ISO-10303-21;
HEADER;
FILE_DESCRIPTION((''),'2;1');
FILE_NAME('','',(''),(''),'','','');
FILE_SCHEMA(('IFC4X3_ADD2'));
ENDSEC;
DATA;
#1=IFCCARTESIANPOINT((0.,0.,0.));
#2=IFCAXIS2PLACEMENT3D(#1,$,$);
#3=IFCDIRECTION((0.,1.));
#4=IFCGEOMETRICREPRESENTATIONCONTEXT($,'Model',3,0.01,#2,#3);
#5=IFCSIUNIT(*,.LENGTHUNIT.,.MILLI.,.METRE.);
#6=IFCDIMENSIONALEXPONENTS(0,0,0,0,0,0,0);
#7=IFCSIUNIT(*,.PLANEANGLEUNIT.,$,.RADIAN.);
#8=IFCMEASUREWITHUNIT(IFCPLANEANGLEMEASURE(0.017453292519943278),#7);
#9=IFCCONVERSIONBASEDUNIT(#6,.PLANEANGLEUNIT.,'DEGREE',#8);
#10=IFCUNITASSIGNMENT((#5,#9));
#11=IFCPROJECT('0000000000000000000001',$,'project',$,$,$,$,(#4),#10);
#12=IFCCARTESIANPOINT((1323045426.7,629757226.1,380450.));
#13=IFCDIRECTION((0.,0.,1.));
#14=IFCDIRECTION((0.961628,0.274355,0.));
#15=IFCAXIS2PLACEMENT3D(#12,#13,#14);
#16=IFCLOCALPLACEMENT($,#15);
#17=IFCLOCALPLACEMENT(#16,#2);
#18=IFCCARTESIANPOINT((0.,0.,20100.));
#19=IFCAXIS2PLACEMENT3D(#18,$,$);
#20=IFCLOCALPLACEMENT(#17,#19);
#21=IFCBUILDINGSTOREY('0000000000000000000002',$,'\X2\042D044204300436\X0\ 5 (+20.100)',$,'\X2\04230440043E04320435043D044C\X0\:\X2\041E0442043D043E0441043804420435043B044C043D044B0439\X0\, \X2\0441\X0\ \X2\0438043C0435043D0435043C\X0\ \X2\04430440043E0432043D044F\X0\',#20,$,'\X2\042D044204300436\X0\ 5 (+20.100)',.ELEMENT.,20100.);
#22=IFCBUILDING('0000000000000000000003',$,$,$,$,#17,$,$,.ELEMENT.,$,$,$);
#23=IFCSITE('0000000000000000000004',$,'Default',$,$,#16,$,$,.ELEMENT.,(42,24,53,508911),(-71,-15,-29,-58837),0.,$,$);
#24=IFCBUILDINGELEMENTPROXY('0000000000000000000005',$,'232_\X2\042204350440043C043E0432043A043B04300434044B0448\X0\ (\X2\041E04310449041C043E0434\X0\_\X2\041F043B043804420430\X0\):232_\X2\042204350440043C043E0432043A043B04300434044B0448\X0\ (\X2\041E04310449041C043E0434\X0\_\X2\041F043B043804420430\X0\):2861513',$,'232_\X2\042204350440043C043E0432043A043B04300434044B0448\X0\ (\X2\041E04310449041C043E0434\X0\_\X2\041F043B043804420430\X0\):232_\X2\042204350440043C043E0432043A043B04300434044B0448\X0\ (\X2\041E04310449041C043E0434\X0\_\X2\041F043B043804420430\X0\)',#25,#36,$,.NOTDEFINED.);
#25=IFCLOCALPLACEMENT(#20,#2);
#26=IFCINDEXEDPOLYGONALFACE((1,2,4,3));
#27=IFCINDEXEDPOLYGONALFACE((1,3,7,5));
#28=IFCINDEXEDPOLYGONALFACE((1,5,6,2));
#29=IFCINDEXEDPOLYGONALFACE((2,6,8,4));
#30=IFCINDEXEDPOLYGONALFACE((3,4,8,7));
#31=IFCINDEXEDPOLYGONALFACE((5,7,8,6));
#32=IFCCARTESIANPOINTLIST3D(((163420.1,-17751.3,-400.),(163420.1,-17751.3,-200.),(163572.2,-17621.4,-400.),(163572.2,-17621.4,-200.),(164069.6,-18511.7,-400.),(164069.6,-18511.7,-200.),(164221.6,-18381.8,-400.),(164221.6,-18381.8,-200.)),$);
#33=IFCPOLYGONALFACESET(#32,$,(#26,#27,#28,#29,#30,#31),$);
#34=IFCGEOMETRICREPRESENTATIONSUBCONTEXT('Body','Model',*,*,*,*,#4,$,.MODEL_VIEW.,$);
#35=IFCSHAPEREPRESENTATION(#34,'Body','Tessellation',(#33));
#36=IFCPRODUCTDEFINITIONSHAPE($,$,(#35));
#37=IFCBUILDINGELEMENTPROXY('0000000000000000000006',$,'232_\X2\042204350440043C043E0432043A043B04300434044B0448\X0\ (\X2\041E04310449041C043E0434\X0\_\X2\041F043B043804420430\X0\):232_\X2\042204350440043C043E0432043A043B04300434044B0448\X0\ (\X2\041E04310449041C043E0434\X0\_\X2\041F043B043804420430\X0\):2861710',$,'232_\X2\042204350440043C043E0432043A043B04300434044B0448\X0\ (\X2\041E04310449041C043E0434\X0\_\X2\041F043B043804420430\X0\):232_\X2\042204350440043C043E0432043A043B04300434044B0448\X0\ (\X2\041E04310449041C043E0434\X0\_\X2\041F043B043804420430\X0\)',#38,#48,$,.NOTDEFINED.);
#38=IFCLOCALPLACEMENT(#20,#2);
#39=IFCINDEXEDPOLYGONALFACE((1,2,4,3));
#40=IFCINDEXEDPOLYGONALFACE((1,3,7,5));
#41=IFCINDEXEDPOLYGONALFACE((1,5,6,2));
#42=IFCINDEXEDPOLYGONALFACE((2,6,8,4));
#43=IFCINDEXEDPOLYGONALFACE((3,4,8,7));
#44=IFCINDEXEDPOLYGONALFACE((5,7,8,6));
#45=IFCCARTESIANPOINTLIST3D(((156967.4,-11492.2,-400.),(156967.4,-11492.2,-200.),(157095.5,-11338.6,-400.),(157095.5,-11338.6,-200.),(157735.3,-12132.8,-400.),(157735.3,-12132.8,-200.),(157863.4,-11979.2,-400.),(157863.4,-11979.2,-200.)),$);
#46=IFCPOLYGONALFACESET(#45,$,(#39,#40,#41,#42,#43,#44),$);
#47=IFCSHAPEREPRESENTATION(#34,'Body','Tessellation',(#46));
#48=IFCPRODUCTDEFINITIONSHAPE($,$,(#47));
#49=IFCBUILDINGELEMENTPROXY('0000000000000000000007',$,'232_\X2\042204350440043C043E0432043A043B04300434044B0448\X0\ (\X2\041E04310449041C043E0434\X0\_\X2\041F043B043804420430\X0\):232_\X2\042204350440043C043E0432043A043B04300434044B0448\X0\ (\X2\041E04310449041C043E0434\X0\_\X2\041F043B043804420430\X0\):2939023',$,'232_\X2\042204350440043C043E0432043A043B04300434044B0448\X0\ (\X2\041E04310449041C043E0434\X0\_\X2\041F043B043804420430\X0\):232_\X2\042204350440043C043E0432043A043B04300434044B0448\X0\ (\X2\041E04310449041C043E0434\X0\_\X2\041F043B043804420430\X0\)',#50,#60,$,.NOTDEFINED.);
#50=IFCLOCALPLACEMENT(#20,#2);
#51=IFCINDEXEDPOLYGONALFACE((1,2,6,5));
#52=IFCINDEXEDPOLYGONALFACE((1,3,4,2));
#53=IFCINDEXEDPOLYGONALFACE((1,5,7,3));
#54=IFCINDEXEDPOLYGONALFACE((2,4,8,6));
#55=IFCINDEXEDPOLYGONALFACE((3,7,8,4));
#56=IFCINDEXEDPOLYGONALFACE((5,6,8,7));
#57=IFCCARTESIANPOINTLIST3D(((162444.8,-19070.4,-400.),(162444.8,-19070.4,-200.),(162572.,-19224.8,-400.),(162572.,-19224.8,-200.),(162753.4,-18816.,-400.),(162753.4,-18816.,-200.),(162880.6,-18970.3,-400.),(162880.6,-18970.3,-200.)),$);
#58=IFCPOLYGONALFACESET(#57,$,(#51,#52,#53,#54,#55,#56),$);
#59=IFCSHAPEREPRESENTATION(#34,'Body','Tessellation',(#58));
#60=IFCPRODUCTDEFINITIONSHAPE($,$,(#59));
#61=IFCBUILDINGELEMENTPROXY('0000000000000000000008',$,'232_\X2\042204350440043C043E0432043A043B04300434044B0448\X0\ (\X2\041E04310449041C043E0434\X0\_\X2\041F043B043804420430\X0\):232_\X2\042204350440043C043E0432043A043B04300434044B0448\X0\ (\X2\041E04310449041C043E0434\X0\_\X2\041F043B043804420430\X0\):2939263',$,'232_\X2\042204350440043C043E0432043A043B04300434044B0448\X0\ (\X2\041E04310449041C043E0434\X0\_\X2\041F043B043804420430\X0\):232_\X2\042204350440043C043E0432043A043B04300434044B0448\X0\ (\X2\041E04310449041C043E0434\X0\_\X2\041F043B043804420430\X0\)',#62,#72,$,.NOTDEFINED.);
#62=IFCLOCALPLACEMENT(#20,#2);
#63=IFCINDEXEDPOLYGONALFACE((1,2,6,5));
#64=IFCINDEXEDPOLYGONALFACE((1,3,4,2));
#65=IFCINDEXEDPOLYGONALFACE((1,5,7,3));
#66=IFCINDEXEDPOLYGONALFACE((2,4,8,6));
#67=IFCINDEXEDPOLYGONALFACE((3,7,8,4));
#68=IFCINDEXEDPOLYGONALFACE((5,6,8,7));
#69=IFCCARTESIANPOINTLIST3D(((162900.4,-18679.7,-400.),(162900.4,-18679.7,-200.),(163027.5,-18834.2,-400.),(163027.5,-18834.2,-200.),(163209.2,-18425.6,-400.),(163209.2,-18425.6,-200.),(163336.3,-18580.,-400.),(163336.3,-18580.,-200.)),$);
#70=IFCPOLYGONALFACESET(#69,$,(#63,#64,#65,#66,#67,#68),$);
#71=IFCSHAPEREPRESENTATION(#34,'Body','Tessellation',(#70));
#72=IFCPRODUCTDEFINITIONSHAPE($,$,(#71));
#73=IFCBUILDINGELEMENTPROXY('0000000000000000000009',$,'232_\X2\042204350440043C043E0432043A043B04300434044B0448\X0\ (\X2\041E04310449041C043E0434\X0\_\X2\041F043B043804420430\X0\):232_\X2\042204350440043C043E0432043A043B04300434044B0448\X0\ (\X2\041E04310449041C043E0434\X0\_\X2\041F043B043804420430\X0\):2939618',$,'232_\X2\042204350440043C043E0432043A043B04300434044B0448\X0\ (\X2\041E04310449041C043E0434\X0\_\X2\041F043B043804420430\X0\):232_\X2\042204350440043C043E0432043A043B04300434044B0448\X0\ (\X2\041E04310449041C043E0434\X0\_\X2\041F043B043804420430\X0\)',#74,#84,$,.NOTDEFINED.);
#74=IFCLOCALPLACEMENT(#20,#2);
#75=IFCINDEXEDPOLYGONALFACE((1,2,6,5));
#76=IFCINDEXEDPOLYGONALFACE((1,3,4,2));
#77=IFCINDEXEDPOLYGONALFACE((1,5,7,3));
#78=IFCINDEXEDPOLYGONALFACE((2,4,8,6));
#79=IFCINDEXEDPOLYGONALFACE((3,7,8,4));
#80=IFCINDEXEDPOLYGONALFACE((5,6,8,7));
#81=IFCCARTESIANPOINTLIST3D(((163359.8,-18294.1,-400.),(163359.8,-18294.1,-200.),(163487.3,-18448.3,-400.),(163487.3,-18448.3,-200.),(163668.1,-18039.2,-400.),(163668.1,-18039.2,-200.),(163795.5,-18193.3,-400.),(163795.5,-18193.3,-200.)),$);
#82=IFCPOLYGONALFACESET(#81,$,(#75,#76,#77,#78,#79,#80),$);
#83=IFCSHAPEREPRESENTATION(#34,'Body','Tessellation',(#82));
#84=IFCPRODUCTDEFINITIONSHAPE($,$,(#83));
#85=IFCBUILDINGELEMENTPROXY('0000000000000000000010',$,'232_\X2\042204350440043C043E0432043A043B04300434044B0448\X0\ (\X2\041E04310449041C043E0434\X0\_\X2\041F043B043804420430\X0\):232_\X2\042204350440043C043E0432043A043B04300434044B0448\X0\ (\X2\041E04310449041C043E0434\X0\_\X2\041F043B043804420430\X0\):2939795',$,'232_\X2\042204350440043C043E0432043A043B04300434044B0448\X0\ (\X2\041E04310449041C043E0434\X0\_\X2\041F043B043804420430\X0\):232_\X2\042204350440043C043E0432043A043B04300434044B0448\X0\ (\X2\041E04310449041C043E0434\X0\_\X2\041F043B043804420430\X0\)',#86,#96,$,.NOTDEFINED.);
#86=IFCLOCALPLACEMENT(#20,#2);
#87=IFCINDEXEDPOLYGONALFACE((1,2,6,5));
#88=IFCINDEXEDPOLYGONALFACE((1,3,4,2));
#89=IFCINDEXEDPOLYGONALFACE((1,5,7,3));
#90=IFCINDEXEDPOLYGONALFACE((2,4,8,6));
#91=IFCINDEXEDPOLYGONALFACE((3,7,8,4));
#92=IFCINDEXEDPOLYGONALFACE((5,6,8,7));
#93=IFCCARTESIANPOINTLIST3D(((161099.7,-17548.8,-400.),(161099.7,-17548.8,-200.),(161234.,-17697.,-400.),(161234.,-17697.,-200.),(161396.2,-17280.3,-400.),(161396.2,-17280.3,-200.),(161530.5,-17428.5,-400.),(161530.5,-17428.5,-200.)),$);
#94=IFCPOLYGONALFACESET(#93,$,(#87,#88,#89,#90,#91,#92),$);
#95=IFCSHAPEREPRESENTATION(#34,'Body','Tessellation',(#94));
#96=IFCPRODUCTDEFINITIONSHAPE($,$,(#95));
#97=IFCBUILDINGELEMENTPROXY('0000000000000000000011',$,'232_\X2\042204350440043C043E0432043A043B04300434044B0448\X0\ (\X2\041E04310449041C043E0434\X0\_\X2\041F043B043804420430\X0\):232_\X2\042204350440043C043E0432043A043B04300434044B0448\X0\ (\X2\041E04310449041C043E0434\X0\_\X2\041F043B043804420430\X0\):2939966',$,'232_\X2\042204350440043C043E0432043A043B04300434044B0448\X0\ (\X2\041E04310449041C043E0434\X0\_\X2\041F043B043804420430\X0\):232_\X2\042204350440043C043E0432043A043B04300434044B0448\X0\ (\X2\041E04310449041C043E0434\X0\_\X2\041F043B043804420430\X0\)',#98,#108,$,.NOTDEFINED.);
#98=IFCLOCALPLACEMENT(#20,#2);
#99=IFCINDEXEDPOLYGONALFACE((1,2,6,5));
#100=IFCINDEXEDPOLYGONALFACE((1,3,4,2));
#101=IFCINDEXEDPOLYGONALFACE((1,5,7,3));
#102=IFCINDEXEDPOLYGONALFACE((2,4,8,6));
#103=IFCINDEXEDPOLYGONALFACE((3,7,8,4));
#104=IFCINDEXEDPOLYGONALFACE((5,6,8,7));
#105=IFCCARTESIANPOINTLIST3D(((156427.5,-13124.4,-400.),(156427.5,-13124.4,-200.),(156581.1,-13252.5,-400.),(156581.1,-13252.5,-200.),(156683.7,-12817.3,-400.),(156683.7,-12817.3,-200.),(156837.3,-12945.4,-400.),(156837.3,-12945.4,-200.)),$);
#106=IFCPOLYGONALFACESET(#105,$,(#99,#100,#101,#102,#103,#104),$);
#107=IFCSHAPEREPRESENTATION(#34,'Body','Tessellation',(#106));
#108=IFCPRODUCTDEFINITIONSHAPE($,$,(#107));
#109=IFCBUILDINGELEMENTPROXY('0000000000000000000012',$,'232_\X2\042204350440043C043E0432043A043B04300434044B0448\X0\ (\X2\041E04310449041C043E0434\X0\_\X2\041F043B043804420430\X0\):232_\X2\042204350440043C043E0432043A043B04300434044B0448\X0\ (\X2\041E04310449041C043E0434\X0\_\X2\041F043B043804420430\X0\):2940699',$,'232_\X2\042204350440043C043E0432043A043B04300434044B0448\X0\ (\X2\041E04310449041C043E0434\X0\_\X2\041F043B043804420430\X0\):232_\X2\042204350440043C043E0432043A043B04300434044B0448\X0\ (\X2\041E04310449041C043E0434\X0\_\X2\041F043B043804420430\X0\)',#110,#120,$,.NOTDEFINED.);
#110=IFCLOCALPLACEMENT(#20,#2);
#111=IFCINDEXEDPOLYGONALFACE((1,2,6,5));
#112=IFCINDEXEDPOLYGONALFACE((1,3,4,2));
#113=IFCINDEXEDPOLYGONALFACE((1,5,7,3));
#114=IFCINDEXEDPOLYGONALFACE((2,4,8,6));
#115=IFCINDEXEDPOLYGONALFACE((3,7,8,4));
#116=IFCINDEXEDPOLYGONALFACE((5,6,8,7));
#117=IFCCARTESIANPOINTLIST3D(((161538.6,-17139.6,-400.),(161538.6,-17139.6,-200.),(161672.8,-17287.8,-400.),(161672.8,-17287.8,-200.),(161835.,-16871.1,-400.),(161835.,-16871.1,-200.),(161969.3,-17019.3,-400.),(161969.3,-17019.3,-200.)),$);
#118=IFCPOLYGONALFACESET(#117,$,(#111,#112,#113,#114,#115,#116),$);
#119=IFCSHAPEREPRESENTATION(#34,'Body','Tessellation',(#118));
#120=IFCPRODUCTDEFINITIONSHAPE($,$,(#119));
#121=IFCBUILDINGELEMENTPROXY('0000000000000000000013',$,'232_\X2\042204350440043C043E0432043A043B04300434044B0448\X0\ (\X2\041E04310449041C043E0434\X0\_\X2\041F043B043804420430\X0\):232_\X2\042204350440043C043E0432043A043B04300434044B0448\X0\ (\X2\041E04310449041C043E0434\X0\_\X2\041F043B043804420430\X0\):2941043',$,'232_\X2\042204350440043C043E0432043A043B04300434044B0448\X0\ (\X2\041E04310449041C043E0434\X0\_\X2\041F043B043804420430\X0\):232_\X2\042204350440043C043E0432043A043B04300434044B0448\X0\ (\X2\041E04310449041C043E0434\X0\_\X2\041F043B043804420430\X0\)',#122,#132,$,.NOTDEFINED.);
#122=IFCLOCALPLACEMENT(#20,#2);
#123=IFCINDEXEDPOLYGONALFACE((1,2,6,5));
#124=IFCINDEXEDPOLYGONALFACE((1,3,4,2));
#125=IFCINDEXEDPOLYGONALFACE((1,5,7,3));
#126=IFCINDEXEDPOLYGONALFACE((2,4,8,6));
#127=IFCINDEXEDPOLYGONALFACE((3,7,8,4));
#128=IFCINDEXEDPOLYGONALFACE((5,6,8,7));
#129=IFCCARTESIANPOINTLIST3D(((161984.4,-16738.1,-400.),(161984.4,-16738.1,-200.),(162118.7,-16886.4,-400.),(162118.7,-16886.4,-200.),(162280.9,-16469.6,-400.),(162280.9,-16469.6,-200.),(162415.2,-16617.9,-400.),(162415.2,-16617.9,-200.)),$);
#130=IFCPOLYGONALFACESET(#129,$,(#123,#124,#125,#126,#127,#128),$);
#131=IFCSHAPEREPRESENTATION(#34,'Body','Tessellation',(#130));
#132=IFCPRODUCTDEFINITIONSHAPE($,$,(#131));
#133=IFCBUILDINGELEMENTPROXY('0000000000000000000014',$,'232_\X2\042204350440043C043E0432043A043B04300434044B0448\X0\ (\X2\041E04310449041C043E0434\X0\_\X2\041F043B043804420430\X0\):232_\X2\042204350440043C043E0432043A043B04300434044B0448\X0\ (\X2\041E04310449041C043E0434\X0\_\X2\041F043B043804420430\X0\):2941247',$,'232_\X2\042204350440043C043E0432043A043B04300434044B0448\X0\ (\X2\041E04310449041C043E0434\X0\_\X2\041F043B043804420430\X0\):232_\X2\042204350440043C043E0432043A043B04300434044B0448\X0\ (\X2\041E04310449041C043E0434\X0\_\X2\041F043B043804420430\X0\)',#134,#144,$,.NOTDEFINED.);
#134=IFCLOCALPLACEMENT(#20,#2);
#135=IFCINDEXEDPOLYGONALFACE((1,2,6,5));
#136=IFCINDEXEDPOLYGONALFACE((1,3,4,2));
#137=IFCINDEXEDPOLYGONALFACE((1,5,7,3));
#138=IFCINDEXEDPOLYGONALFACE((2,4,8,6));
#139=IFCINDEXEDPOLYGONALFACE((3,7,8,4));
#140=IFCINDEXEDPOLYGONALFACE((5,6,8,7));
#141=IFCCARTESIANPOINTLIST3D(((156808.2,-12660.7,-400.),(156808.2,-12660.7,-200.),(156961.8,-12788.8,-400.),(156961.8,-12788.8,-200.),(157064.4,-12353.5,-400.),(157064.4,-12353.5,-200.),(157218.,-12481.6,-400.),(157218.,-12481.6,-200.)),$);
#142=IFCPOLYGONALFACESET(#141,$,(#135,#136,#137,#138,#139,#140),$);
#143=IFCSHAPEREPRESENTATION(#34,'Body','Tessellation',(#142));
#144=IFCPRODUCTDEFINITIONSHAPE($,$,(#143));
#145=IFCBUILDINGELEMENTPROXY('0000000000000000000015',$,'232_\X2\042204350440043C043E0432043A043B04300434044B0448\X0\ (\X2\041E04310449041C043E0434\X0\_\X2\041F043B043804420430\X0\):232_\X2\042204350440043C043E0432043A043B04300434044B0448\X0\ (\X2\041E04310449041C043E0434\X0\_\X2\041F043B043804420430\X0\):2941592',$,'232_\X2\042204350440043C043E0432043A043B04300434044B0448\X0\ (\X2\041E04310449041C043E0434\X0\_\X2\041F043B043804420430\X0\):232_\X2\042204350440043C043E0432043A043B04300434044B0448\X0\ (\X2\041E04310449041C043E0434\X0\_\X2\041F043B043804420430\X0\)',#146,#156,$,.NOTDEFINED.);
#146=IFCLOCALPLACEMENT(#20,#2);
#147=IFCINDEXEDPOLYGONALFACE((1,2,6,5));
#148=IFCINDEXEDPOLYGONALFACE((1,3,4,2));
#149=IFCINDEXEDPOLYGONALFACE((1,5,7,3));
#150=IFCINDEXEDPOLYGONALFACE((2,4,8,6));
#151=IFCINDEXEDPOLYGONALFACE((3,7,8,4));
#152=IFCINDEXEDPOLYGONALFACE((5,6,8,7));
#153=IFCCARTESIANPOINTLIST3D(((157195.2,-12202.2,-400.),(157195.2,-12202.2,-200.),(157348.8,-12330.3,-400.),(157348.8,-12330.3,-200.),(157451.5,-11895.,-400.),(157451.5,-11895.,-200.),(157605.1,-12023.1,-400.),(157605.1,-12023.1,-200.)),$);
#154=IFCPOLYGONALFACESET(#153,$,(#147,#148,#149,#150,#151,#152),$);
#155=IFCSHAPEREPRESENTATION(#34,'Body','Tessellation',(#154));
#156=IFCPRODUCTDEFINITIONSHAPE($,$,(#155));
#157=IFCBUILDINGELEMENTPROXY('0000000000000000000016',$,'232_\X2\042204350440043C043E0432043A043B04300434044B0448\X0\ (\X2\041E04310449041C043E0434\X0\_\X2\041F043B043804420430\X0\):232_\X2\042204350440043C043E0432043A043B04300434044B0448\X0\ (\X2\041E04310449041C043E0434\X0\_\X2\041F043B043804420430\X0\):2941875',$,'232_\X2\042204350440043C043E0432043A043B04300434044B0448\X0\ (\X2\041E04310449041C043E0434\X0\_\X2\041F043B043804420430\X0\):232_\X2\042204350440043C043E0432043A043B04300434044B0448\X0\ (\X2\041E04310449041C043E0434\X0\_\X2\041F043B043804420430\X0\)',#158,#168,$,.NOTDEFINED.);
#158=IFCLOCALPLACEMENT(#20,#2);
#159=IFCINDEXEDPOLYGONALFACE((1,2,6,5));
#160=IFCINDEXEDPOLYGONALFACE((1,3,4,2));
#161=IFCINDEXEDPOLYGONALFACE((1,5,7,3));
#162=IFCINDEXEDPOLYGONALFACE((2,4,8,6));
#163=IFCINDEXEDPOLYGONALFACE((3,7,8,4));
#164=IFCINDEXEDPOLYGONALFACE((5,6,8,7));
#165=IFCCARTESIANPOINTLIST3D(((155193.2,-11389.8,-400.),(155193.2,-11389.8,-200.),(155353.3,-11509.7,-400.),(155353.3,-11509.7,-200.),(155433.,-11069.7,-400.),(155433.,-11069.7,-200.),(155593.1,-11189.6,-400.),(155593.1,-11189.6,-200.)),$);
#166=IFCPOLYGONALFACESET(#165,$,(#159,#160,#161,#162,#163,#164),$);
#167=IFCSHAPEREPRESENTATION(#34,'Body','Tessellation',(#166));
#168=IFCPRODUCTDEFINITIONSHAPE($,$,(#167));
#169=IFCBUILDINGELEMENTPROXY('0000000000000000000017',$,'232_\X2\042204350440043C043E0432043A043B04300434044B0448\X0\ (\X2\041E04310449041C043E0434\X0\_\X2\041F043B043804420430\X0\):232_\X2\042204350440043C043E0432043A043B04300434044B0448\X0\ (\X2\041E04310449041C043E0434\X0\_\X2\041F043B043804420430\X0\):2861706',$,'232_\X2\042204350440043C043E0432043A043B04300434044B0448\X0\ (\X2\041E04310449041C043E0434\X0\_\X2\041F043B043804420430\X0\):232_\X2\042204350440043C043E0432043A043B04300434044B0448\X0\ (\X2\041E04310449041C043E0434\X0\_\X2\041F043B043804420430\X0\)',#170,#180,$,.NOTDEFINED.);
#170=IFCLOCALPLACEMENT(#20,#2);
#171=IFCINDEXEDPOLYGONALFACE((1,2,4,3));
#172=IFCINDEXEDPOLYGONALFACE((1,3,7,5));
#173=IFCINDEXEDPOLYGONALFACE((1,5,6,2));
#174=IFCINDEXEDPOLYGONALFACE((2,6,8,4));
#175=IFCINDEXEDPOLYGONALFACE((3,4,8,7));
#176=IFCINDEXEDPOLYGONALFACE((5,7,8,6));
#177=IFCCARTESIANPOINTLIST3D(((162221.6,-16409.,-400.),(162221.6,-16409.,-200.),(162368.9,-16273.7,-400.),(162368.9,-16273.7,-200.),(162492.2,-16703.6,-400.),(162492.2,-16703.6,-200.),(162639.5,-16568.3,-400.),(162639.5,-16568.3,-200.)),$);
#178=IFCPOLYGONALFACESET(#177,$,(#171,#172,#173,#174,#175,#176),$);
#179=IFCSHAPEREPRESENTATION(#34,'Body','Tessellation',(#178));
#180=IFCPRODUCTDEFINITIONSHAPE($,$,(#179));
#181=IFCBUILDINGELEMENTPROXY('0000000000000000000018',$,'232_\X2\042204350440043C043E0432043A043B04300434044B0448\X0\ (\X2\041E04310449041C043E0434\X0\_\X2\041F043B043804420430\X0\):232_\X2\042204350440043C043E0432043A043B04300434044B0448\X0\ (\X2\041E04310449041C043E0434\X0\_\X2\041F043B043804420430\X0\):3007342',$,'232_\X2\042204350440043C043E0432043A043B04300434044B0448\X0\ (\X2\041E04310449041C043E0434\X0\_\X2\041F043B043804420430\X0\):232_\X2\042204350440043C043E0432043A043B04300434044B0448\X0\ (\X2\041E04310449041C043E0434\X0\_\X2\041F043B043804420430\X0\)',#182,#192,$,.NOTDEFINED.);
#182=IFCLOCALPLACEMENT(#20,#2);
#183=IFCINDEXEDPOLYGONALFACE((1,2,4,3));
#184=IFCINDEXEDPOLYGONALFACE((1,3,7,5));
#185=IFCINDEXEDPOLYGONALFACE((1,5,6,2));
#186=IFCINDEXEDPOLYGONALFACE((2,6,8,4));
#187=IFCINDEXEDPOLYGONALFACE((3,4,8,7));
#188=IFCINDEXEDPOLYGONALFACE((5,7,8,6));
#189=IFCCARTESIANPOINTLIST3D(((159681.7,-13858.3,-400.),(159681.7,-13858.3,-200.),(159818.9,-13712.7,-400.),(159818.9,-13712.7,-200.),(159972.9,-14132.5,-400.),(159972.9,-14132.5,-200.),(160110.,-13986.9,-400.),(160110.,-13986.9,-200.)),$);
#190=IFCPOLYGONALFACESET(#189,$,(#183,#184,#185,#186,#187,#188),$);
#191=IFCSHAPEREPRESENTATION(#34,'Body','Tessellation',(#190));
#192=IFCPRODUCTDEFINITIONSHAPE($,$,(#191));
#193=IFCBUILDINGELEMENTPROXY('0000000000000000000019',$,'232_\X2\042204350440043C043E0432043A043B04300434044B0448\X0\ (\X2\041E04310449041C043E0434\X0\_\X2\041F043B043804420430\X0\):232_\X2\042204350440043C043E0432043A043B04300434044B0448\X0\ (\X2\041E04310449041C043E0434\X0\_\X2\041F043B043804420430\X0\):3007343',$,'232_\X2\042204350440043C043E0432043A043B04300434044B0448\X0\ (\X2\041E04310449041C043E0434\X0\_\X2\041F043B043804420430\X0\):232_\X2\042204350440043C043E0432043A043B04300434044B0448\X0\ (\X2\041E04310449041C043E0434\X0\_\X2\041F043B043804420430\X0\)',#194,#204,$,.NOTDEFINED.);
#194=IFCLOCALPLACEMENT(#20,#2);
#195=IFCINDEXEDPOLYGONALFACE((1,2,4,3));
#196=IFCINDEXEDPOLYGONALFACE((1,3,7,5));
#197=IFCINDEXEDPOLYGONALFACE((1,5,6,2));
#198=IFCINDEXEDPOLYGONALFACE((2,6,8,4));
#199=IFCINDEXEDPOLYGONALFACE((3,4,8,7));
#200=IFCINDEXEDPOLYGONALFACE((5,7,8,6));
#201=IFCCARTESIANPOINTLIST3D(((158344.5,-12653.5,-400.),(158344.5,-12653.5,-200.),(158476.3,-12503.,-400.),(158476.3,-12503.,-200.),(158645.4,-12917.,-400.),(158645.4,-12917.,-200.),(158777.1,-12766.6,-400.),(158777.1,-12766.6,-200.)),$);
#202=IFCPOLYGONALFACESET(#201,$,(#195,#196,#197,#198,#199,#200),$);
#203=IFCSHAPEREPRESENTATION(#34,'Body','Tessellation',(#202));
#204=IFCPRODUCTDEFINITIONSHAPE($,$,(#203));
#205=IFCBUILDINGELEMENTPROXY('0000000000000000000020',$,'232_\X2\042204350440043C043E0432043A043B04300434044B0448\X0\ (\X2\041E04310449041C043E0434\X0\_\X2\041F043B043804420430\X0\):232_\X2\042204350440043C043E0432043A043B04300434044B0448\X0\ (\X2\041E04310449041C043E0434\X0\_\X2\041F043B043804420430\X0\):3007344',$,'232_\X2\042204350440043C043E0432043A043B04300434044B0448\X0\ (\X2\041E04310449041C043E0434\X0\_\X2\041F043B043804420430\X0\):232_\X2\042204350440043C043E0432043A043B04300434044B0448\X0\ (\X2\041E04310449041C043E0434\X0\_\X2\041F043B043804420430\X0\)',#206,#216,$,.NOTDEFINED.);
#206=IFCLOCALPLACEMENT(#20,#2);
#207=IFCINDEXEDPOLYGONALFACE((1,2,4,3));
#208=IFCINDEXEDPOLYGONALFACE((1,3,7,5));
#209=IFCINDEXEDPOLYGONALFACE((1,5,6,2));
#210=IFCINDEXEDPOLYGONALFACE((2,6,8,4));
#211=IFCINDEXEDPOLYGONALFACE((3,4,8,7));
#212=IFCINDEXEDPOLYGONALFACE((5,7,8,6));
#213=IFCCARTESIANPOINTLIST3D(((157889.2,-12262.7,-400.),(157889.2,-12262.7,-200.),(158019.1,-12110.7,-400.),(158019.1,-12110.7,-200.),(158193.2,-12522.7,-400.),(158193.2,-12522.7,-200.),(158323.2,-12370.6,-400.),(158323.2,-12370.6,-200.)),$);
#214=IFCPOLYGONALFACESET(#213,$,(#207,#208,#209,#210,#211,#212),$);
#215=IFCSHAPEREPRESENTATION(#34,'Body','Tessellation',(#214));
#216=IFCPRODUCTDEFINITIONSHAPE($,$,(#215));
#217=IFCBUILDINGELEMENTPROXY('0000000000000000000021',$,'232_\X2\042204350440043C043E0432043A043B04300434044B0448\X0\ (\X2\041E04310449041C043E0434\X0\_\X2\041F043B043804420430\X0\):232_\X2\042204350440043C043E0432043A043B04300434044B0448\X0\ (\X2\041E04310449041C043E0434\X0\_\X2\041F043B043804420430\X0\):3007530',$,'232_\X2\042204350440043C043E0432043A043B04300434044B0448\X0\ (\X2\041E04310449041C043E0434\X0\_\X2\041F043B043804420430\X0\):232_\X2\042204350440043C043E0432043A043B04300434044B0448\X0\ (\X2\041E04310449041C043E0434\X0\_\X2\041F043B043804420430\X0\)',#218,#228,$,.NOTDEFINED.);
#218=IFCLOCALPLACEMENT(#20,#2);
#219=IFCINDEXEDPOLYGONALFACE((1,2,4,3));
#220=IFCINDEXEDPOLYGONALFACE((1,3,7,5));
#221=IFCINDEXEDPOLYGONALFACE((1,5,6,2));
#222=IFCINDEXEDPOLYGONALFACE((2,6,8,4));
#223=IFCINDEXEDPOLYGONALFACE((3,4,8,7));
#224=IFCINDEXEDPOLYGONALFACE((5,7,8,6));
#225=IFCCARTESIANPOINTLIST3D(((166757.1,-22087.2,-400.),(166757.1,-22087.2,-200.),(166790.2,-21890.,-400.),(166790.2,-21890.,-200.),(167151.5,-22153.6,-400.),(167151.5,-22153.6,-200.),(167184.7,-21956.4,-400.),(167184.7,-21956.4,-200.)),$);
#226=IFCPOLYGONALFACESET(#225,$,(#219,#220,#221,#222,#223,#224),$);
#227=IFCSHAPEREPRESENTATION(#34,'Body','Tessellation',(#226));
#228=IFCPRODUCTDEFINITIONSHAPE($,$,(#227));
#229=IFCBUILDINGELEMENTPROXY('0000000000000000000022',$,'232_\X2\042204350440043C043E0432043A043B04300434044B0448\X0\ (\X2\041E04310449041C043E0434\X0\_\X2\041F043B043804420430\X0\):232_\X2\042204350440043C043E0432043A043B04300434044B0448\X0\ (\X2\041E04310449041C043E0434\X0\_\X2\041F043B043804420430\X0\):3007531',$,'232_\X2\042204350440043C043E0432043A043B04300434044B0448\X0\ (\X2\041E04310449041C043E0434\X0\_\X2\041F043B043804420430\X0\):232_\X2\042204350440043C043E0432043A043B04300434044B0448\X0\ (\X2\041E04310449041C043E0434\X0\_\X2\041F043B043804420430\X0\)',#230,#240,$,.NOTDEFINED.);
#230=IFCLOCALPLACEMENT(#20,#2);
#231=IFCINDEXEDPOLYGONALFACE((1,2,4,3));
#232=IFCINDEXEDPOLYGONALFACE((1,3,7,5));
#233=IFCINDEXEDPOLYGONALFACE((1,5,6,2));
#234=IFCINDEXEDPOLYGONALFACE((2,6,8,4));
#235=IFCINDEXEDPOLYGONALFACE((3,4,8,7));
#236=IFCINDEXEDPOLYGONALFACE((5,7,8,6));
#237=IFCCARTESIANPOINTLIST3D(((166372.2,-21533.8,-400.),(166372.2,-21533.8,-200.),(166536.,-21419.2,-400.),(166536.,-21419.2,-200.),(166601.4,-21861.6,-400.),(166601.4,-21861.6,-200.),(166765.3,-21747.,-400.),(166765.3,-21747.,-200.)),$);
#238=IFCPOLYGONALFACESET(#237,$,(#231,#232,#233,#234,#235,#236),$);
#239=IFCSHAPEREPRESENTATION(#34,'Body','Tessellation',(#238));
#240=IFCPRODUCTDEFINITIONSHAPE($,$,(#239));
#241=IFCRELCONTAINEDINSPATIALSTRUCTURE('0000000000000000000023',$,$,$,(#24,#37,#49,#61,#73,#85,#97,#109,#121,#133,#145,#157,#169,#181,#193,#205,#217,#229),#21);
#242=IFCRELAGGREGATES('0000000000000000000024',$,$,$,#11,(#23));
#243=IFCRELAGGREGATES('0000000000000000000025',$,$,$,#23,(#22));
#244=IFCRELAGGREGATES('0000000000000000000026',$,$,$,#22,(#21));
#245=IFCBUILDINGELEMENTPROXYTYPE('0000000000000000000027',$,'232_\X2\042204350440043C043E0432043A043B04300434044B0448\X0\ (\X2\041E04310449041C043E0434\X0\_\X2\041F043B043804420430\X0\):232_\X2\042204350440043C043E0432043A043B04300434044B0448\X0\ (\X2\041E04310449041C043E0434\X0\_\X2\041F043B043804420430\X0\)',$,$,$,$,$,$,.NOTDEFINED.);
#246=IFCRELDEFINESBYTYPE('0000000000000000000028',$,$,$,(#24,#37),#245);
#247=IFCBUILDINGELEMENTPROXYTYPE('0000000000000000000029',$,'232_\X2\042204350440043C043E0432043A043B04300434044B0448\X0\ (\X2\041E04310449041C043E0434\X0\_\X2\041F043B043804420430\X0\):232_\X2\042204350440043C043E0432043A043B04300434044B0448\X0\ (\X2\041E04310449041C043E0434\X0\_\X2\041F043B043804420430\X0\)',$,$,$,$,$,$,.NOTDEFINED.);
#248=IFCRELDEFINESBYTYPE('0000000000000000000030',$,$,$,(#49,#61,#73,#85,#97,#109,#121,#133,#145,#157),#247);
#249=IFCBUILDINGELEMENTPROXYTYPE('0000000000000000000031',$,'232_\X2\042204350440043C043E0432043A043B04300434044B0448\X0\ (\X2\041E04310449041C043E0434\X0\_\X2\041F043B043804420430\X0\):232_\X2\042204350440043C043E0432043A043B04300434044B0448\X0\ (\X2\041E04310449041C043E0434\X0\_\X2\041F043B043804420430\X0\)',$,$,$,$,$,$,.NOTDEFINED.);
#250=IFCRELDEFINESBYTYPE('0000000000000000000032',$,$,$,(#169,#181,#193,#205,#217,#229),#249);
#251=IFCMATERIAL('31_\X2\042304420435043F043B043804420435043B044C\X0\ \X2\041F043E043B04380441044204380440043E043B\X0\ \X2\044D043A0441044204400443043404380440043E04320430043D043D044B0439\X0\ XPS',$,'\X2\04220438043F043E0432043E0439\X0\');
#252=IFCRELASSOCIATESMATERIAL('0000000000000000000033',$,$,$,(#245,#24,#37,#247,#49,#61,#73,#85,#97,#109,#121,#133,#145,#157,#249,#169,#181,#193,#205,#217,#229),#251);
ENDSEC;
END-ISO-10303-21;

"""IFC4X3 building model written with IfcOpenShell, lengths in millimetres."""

from ifc_helpers import new_model, entity, si_unit, converted_unit, direction, frame, origin, origin_2d_with_axis, place, context, subcontext, project, spatial, rectangle, extrude, source, transform, mapped, material, type_object, type_shapes, element, save


model = new_model("IFC4X3")

# Units and contexts
model_context = context("Model", 3, precision=0.01, world=origin(), true_north=direction((0.0, 1.0)))
body_context = subcontext(model_context, "Body", "Model", "MODEL_VIEW")
ifc_project = project(units=[si_unit("LENGTHUNIT", "METRE", prefix="MILLI"), converted_unit("PLANEANGLEUNIT", "DEGREE", entity("IfcPlaneAngleMeasure", 0.017453292519943278), si_unit("PLANEANGLEUNIT", "RADIAN"), dimensions=[0, 0, 0, 0, 0, 0, 0])], contexts=[model_context])

# Site, building, storey
site_placement = place(None, frame((1323045426.7, 629757226.1, 380450.0), z_axis=(0.0, 0.0, 1.0), x_axis=(0.961628, 0.274355, 0.0)))
site = spatial("IfcSite", under=ifc_project, at=site_placement, Name="Default", CompositionType="ELEMENT", RefLatitude=(42, 24, 53, 508911), RefLongitude=(-71, -15, -29, -58837), RefElevation=0.0)
building_placement = place(site_placement, origin())
building = spatial("IfcBuilding", under=site, at=building_placement, CompositionType="ELEMENT")
storey_placement = place(building_placement, frame((0.0, 0.0, 20100.0)))
storey = spatial("IfcBuildingStorey", under=building, at=storey_placement, Name="Этаж 5 (+20.100)", ObjectType="Уровень:Относительный, с именем уровня", LongName="Этаж 5 (+20.100)", CompositionType="ELEMENT", Elevation=20100.0)

# Building element proxies
ifc_material = material(Name="31_Утеплитель Полистирол экструдированный XPS", Category="Типовой")
building_element_proxy_type_1 = type_object("IfcBuildingElementProxyType", Name="232_Термовкладыш (ОбщМод_Плита):232_Термовкладыш (ОбщМод_Плита)", PredefinedType="NOTDEFINED", material=ifc_material)
shared_shape_1 = source(origin(), body_context, "Body", "SweptSolid", [
    extrude(rectangle(XDim=1000.0, YDim=200.0, at=origin_2d_with_axis()), frame((500.0, 0.0, -200.0), z_axis=(0.0, 0.0, 1.0), x_axis=(-1.0, 0.0, 0.0)), (0.0, 0.0, 1.0), 200.0),
])
type_shapes(building_element_proxy_type_1, [shared_shape_1])
for number, where, z_axis, x_axis, name in (
    (1, (163496.2, -17686.3, -200.0), (0.0, 0.0, 1.0), (0.649416, -0.760434, 0.0), "232_Термовкладыш (ОбщМод_Плита):232_Термовкладыш (ОбщМод_Плита):2861513"),
    (2, (157031.4, -11415.4, -200.0), (0.0, 0.0, 1.0), (0.767901, -0.640568, 0.0), "232_Термовкладыш (ОбщМод_Плита):232_Термовкладыш (ОбщМод_Плита):2861710"),
):
    element("IfcBuildingElementProxy", number, at=place(storey_placement, frame(where, z_axis=z_axis, x_axis=x_axis)), inside=storey, type_object=building_element_proxy_type_1, material=ifc_material, Name=name, ObjectType="232_Термовкладыш (ОбщМод_Плита):232_Термовкладыш (ОбщМод_Плита)", PredefinedType="NOTDEFINED", context=body_context, shape_type="MappedRepresentation", body=[
        mapped(shared_shape_1, transform((0.0, 0.0, 0.0), scale=1.0)),
    ])
building_element_proxy_type_2 = type_object("IfcBuildingElementProxyType", Name="232_Термовкладыш (ОбщМод_Плита):232_Термовкладыш (ОбщМод_Плита)", PredefinedType="NOTDEFINED", material=ifc_material)
shared_shape_2 = source(origin(), body_context, "Body", "SweptSolid", [
    extrude(rectangle(XDim=200.0, YDim=400.0, at=origin_2d_with_axis()), frame((100.0, 0.0, -200.0), z_axis=(0.0, 0.0, 1.0), x_axis=(-1.0, 0.0, 0.0)), (0.0, 0.0, 1.0), 200.0),
])
type_shapes(building_element_proxy_type_2, [shared_shape_2])
for number, where, z_axis, x_axis, name in (
    (3, (162599.1, -18943.2, -200.0), (0.0, 0.0, 1.0), (0.636186, -0.771536, 0.0), "232_Термовкладыш (ОбщМод_Плита):232_Термовкладыш (ОбщМод_Плита):2939023"),
    (4, (163054.8, -18552.7, -200.0), (0.0, 0.0, 1.0), (0.635444, -0.772147, 0.0), "232_Термовкладыш (ОбщМод_Плита):232_Термовкладыш (ОбщМод_Плита):2939263"),
    (5, (163513.9, -18166.7, -200.0), (0.0, 0.0, 1.0), (0.637306, -0.770611, 0.0), "232_Термовкладыш (ОбщМод_Плита):232_Термовкладыш (ОбщМод_Плита):2939618"),
    (6, (161248.0, -17414.5, -200.0), (0.0, 0.0, 1.0), (0.671284, -0.7412, 0.0), "232_Термовкладыш (ОбщМод_Плита):232_Термовкладыш (ОбщМод_Плита):2939795"),
    (7, (156555.6, -12970.8, -200.0), (0.0, 0.0, 1.0), (0.767907, -0.640562, 0.0), "232_Термовкладыш (ОбщМод_Плита):232_Термовкладыш (ОбщМод_Плита):2939966"),
    (8, (161686.8, -17005.3, -200.0), (0.0, 0.0, 1.0), (0.671284, -0.7412, 0.0), "232_Термовкладыш (ОбщМод_Плита):232_Термовкладыш (ОбщМод_Плита):2940699"),
    (9, (162132.7, -16603.9, -200.0), (0.0, 0.0, 1.0), (0.671284, -0.7412, 0.0), "232_Термовкладыш (ОбщМод_Плита):232_Термовкладыш (ОбщМод_Плита):2941043"),
    (10, (156936.3, -12507.1, -200.0), (0.0, 0.0, 1.0), (0.767907, -0.640562, 0.0), "232_Термовкладыш (ОбщМод_Плита):232_Термовкладыш (ОбщМод_Плита):2941247"),
    (11, (157323.4, -12048.6, -200.0), (0.0, 0.0, 1.0), (0.767907, -0.640562, 0.0), "232_Термовкладыш (ОбщМод_Плита):232_Термовкладыш (ОбщМод_Плита):2941592"),
    (12, (155313.1, -11229.7, -200.0), (0.0, 0.0, 1.0), (0.800379, -0.599495, 0.0), "232_Термовкладыш (ОбщМод_Плита):232_Термовкладыш (ОбщМод_Плита):2941875"),
):
    element("IfcBuildingElementProxy", number, at=place(storey_placement, frame(where, z_axis=z_axis, x_axis=x_axis)), inside=storey, type_object=building_element_proxy_type_2, material=ifc_material, Name=name, ObjectType="232_Термовкладыш (ОбщМод_Плита):232_Термовкладыш (ОбщМод_Плита)", PredefinedType="NOTDEFINED", context=body_context, shape_type="MappedRepresentation", body=[
        mapped(shared_shape_2, transform((0.0, 0.0, 0.0), scale=1.0)),
    ])
building_element_proxy_type_3 = type_object("IfcBuildingElementProxyType", Name="232_Термовкладыш (ОбщМод_Плита):232_Термовкладыш (ОбщМод_Плита)", PredefinedType="NOTDEFINED", material=ifc_material)
shared_shape_3 = source(origin(), body_context, "Body", "SweptSolid", [
    extrude(rectangle(XDim=400.0, YDim=200.0, at=origin_2d_with_axis()), frame((200.0, 0.0, -200.0), z_axis=(0.0, 0.0, 1.0), x_axis=(-1.0, 0.0, 0.0)), (0.0, 0.0, 1.0), 200.0),
])
type_shapes(building_element_proxy_type_3, [shared_shape_3])
for number, where, z_axis, x_axis, name in (
    (13, (162295.3, -16341.4, -200.0), (0.0, 0.0, 1.0), (0.676482, -0.736459, 0.0), "232_Термовкладыш (ОбщМод_Плита):232_Термовкладыш (ОбщМод_Плита):2861706"),
    (14, (159750.3, -13785.5, -200.0), (0.0, 0.0, 1.0), (0.727927, -0.685655, 0.0), "232_Термовкладыш (ОбщМод_Плита):232_Термовкладыш (ОбщМод_Плита):3007342"),
    (15, (158410.4, -12578.3, -200.0), (0.0, 0.0, 1.0), (0.752238, -0.658891, 0.0), "232_Термовкладыш (ОбщМод_Плита):232_Термовкладыш (ОбщМод_Плита):3007343"),
    (16, (157954.2, -12186.7, -200.0), (0.0, 0.0, 1.0), (0.760125, -0.649777, 0.0), "232_Термовкладыш (ОбщМод_Плита):232_Термовкладыш (ОбщМод_Плита):3007344"),
    (17, (166773.6, -21988.6, -200.0), (0.0, 0.0, 1.0), (0.986154, -0.165835, 0.0), "232_Термовкладыш (ОбщМод_Плита):232_Термовкладыш (ОбщМод_Плита):3007530"),
    (18, (166454.1, -21476.5, -200.0), (0.0, 0.0, 1.0), (0.573188, -0.819424, 0.0), "232_Термовкладыш (ОбщМод_Плита):232_Термовкладыш (ОбщМод_Плита):3007531"),
):
    element("IfcBuildingElementProxy", number, at=place(storey_placement, frame(where, z_axis=z_axis, x_axis=x_axis)), inside=storey, type_object=building_element_proxy_type_3, material=ifc_material, Name=name, ObjectType="232_Термовкладыш (ОбщМод_Плита):232_Термовкладыш (ОбщМод_Плита)", PredefinedType="NOTDEFINED", context=body_context, shape_type="MappedRepresentation", body=[
        mapped(shared_shape_3, transform((0.0, 0.0, 0.0), scale=1.0)),
    ])

save(model, "model.ifc")
